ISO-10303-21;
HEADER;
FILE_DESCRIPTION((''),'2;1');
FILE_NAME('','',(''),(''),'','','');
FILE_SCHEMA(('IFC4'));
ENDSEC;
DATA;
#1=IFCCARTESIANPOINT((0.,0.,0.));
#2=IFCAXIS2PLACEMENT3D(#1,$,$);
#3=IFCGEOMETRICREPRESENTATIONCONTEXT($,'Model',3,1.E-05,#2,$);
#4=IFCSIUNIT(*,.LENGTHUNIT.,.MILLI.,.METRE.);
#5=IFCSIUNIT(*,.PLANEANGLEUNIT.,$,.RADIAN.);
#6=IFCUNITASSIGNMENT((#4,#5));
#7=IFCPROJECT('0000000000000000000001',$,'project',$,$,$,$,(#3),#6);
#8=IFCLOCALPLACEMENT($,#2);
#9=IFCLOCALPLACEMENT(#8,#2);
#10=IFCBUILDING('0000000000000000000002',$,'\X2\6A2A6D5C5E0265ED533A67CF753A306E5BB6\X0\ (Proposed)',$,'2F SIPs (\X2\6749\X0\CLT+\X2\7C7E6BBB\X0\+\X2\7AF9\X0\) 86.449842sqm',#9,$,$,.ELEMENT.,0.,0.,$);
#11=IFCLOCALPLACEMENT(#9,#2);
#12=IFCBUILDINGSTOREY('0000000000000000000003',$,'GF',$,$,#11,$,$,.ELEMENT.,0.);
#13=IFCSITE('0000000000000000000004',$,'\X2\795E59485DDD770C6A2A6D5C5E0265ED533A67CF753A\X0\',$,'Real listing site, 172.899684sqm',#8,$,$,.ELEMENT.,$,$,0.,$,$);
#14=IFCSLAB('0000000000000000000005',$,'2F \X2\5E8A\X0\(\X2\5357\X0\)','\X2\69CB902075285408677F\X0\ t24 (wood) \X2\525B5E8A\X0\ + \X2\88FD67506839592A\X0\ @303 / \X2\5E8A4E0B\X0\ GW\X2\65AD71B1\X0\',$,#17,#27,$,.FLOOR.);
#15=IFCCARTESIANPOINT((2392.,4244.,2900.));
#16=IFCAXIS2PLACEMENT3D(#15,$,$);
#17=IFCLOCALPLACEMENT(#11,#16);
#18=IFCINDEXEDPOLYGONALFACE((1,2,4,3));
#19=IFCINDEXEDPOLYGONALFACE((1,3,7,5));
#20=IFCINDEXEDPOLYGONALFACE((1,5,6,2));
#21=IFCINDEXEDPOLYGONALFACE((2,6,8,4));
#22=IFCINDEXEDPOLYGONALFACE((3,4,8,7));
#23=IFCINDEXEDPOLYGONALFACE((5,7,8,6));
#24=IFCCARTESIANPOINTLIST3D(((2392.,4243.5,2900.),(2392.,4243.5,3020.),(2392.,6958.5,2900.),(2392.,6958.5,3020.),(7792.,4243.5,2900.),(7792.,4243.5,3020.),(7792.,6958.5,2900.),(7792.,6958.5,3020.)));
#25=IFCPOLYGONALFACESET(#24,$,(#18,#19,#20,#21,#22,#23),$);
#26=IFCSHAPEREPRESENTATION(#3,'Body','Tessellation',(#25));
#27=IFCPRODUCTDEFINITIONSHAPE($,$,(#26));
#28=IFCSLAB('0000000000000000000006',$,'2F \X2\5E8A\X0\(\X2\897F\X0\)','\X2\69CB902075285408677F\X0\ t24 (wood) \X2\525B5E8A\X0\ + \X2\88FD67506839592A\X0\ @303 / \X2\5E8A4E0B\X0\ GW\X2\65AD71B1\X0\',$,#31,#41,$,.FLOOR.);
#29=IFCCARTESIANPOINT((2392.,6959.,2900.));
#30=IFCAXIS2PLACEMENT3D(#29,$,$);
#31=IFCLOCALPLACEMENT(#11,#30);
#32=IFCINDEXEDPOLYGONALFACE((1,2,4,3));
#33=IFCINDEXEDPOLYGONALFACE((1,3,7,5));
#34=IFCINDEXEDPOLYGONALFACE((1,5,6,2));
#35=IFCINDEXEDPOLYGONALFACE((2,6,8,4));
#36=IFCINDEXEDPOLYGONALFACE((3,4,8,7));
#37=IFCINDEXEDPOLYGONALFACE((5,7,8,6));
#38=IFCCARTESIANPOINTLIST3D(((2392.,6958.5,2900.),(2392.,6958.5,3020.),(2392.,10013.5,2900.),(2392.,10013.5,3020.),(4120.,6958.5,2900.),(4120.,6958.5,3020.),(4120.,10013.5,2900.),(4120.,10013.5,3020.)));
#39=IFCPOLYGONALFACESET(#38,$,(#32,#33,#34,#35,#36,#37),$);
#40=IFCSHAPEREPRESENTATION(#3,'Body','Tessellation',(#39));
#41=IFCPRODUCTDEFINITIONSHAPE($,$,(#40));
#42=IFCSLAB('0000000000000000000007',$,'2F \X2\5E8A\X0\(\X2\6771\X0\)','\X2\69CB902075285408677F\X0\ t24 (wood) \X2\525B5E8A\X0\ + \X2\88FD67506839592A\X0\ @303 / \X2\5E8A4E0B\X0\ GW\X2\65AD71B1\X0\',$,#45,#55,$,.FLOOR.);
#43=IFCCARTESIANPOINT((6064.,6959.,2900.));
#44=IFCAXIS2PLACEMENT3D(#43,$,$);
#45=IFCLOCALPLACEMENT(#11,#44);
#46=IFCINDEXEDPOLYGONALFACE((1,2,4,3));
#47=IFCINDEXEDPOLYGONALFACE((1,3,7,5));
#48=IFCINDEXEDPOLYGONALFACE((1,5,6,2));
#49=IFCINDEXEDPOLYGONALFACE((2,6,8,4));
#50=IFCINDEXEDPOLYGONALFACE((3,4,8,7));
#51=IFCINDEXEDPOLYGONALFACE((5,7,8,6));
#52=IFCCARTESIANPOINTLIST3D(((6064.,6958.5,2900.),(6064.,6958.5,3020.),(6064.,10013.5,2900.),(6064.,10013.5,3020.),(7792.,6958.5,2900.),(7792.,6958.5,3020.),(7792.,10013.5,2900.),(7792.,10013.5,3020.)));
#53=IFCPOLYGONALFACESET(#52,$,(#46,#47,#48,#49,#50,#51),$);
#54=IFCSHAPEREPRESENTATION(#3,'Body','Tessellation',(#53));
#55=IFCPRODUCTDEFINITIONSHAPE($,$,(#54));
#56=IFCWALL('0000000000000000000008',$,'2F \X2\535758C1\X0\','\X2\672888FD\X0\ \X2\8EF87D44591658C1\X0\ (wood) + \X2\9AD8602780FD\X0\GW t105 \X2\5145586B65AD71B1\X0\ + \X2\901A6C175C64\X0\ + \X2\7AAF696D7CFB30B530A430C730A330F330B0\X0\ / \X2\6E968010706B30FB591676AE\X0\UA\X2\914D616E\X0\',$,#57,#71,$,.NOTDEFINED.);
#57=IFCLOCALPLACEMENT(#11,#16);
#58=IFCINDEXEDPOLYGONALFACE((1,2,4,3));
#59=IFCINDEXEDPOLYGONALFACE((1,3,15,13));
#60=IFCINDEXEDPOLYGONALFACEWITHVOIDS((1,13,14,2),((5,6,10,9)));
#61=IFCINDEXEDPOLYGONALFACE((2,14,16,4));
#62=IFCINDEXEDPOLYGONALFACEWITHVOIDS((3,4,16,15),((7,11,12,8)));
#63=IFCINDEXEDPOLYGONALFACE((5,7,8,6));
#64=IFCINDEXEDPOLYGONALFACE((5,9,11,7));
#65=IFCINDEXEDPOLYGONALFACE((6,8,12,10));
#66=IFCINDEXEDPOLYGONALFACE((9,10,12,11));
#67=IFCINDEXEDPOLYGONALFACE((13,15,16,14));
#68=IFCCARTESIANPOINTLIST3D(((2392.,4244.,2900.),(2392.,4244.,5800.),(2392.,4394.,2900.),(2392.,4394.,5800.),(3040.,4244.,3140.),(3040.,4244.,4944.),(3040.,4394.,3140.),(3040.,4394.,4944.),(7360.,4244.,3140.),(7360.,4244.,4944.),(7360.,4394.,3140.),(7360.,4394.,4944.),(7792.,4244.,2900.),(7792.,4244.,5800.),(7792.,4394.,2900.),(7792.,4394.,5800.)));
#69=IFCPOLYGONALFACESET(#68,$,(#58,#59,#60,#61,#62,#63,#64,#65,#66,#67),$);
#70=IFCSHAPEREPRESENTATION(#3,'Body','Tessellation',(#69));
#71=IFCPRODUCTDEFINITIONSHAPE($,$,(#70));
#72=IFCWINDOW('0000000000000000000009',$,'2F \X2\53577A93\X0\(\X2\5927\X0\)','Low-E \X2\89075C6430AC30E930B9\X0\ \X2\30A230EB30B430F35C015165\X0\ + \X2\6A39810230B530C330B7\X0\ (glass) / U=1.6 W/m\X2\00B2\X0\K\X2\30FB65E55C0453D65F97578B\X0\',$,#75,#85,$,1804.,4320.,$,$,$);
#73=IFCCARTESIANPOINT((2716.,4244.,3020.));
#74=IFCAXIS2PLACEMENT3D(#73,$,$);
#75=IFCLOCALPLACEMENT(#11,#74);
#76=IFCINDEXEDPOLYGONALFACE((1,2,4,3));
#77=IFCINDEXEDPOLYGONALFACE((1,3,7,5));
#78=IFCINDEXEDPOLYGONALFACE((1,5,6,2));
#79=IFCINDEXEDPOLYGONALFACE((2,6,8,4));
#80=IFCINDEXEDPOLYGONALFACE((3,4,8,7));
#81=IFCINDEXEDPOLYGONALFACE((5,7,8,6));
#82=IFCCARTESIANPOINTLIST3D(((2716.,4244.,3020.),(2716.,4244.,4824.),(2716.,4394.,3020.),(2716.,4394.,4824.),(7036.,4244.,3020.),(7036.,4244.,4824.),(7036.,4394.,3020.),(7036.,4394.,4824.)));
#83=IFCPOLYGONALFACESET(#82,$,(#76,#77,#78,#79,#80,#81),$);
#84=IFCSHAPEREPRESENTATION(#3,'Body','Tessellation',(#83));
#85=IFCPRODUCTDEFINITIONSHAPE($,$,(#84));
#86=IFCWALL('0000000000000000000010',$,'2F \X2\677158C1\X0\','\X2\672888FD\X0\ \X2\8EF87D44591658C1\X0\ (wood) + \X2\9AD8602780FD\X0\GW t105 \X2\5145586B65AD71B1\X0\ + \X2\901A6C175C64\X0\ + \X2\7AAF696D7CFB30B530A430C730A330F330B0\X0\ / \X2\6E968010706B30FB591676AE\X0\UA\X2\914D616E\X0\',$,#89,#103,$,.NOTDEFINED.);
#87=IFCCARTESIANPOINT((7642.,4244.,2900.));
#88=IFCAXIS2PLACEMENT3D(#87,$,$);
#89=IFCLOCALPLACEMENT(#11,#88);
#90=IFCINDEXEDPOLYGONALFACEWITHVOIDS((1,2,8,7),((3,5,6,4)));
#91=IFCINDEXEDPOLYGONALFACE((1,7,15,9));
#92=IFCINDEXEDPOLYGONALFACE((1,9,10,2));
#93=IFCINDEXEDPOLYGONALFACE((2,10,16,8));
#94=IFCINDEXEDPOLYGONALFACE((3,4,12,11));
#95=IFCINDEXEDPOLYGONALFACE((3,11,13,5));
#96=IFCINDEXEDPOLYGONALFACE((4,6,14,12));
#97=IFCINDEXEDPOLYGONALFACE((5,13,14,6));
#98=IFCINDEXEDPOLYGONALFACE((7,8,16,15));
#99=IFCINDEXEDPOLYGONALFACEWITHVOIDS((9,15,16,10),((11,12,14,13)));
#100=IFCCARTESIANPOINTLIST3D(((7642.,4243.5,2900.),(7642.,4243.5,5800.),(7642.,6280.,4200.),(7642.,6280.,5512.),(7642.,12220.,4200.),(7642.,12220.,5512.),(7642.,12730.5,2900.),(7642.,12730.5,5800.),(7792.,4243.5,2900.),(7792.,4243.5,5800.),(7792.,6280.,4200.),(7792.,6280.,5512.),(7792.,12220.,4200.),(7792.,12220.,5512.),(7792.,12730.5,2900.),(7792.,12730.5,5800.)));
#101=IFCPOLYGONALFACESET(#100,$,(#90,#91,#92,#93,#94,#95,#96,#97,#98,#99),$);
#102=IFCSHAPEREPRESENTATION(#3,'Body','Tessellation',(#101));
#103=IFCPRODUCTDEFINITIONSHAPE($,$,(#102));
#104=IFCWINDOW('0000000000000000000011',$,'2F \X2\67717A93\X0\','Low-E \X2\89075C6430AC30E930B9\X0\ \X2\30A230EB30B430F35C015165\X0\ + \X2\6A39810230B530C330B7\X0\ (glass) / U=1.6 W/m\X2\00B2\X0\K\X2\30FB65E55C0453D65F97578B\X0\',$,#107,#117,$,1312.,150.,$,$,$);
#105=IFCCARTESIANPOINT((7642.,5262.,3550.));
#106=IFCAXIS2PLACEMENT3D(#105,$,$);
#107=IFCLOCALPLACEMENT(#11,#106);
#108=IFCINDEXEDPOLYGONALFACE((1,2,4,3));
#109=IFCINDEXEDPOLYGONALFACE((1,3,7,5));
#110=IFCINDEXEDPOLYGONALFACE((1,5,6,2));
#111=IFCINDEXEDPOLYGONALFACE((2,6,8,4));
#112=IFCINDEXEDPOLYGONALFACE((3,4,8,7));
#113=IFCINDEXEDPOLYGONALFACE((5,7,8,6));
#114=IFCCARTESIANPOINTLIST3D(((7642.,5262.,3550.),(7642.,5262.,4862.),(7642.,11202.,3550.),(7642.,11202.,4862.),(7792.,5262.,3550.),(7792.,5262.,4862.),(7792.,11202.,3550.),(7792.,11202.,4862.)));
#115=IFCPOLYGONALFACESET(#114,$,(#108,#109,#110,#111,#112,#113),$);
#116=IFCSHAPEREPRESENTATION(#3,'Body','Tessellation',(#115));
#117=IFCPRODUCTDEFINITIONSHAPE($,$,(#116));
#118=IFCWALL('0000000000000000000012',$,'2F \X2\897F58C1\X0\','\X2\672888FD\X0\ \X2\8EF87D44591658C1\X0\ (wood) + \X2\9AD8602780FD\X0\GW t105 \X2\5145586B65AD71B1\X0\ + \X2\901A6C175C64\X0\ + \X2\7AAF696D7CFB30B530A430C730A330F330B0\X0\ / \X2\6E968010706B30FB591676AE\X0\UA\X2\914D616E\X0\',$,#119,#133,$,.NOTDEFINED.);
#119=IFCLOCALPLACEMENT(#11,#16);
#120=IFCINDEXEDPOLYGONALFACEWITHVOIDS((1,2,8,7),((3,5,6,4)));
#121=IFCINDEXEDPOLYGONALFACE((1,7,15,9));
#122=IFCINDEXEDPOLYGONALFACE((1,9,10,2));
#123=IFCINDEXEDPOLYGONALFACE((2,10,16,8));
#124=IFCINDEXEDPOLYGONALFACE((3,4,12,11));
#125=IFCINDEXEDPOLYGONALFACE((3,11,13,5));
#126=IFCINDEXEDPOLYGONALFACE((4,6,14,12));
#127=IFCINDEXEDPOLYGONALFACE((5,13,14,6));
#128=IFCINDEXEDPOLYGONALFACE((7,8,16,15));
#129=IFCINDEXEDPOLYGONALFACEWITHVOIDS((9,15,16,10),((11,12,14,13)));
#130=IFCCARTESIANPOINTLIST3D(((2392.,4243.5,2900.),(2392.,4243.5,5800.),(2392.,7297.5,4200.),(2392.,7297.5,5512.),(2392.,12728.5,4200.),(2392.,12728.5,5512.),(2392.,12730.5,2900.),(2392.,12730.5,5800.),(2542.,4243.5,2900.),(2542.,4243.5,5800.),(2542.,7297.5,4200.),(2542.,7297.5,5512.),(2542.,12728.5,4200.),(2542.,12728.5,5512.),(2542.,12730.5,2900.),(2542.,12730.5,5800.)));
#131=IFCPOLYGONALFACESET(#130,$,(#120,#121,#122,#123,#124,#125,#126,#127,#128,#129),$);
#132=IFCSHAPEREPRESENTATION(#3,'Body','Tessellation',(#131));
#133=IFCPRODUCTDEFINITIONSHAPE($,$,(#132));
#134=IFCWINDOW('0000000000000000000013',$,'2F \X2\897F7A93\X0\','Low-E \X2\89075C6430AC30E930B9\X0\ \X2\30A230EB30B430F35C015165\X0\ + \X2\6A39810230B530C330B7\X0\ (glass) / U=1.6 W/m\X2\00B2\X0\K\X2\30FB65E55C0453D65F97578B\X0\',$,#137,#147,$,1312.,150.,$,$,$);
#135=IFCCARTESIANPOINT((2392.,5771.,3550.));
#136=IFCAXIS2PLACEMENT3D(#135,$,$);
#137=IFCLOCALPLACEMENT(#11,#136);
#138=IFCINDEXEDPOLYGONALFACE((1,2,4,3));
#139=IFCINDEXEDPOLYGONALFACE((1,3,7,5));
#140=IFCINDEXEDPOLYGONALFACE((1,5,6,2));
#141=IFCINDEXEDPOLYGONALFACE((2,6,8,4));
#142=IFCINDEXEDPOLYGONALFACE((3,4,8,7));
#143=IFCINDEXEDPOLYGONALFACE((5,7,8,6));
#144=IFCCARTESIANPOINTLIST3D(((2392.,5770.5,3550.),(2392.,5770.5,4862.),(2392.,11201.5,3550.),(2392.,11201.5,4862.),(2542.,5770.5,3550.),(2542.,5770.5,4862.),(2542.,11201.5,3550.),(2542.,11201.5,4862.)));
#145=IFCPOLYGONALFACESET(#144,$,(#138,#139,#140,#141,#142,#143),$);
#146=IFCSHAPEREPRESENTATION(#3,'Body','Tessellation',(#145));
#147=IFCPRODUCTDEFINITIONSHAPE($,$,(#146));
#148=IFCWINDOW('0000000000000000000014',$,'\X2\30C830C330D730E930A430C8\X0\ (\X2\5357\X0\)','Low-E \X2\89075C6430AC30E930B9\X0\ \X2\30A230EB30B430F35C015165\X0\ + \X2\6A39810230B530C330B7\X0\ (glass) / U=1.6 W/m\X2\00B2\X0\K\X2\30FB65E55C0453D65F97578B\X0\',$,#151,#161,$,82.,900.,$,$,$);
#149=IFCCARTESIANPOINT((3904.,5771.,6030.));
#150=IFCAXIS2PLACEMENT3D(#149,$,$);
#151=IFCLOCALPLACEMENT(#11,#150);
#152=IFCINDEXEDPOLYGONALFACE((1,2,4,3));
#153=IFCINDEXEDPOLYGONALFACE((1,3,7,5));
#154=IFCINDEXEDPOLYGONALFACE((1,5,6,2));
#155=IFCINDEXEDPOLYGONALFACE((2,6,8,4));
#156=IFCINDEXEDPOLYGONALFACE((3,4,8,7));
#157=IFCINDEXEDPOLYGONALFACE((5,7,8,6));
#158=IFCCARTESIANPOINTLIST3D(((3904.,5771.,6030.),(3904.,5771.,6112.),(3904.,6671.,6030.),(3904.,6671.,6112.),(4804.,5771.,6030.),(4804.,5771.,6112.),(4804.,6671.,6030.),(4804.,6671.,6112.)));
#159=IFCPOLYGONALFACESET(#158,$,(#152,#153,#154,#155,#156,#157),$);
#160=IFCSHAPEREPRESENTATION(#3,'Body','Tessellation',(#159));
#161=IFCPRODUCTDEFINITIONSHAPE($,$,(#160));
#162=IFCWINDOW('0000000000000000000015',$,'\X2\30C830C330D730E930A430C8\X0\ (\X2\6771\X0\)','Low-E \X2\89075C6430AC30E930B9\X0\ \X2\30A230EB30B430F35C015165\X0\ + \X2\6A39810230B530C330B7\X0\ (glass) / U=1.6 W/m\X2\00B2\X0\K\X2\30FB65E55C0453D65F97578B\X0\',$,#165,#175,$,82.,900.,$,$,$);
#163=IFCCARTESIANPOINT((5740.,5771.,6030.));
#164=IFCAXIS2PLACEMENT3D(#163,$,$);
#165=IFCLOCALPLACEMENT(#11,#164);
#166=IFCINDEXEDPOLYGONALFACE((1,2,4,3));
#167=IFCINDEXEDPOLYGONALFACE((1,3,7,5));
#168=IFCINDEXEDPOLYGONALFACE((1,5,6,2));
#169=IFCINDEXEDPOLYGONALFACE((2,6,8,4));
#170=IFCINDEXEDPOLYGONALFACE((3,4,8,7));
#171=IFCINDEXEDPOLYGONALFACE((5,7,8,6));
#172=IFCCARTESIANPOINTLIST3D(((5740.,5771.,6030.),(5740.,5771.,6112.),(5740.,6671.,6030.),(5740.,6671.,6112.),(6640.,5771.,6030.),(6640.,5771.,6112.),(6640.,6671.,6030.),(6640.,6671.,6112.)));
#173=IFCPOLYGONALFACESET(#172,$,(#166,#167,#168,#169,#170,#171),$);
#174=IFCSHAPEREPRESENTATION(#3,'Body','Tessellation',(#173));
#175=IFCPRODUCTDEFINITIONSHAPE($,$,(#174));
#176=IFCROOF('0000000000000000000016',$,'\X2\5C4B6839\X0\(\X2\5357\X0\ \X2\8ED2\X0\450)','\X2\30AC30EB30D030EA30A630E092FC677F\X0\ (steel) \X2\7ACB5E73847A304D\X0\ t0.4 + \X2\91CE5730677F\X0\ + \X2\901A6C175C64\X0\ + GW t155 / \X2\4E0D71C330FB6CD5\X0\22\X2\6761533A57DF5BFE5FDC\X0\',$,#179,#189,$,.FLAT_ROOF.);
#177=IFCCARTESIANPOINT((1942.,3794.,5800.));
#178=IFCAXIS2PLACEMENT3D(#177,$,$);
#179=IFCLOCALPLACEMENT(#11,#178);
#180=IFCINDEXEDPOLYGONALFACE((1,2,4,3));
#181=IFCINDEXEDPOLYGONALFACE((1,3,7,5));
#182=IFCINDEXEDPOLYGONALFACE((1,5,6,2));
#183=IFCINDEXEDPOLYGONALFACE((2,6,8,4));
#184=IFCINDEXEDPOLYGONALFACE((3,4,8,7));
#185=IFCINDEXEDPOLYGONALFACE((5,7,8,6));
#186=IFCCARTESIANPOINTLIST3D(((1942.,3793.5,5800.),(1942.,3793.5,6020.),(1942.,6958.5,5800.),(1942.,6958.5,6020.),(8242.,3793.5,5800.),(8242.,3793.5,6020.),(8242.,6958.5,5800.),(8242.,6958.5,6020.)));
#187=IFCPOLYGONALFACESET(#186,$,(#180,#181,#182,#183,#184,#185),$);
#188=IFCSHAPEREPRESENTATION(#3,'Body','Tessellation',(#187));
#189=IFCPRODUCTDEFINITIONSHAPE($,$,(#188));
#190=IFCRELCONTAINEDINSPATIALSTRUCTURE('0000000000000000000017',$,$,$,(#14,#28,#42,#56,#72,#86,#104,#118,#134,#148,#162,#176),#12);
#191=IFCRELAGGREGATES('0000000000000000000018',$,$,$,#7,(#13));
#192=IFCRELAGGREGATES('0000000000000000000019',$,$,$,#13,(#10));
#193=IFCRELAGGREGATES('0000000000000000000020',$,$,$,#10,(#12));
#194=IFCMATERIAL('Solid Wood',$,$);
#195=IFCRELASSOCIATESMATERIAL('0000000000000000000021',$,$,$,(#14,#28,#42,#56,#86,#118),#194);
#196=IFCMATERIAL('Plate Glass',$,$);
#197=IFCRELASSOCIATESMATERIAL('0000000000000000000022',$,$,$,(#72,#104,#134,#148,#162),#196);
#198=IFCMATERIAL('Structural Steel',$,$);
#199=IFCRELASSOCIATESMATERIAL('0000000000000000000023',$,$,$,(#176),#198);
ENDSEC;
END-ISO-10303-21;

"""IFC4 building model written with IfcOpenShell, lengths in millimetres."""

from ifc_helpers import new_model, si_unit, frame, frame_2d, origin, place, context, project, spatial, rectangle, extrude, material, element, fill, save


model = new_model("IFC4")

# Units and contexts
model_context = context("Model", 3, precision=1e-05, world=origin())
ifc_project = project(units=[si_unit("LENGTHUNIT", "METRE", prefix="MILLI"), si_unit("PLANEANGLEUNIT", "RADIAN")], contexts=[model_context])

# Site, building, storey
site_placement = place(None, origin())
site = spatial("IfcSite", under=ifc_project, at=site_placement, Name="神奈川県横浜市旭区柏町", ObjectType="Real listing site, 172.899684sqm", CompositionType="ELEMENT", RefElevation=0.0)
building_placement = place(site_placement, origin())
building = spatial("IfcBuilding", under=site, at=building_placement, Name="横浜市旭区柏町の家 (Proposed)", ObjectType="2F SIPs (杉CLT+籾殻+竹) 86.449842sqm", CompositionType="ELEMENT", ElevationOfRefHeight=0.0, ElevationOfTerrain=0.0)
storey_placement = place(building_placement, origin())
storey = spatial("IfcBuildingStorey", under=building, at=storey_placement, Name="GF", CompositionType="ELEMENT", Elevation=0.0)

# Slabs
ifc_material_1 = material(Name="Solid Wood")
slab_1_placement = place(storey_placement, frame((2392.0, 4244.0, 2900.0)))
element("IfcSlab", 1, at=slab_1_placement, inside=storey, material=ifc_material_1, Name="2F 床(南)", Description="構造用合板 t24 (wood) 剛床 + 製材根太 @303 / 床下 GW断熱", PredefinedType="FLOOR", context=model_context, shape_type="SweptSolid", body=[
    extrude(rectangle(XDim=5400.0, YDim=2715.0, at=frame_2d((2700.0, 1357.0))), frame((2392.0, 4244.0, 2900.0)), (0.0, 0.0, 1.0), 120.0),
])
slab_2_placement = place(storey_placement, frame((2392.0, 6959.0, 2900.0)))
element("IfcSlab", 2, at=slab_2_placement, inside=storey, material=ifc_material_1, Name="2F 床(西)", Description="構造用合板 t24 (wood) 剛床 + 製材根太 @303 / 床下 GW断熱", PredefinedType="FLOOR", context=model_context, shape_type="SweptSolid", body=[
    extrude(rectangle(XDim=1728.0, YDim=3055.0, at=frame_2d((864.0, 1527.0))), frame((2392.0, 6959.0, 2900.0)), (0.0, 0.0, 1.0), 120.0),
])
slab_3_placement = place(storey_placement, frame((6064.0, 6959.0, 2900.0)))
element("IfcSlab", 3, at=slab_3_placement, inside=storey, material=ifc_material_1, Name="2F 床(東)", Description="構造用合板 t24 (wood) 剛床 + 製材根太 @303 / 床下 GW断熱", PredefinedType="FLOOR", context=model_context, shape_type="SweptSolid", body=[
    extrude(rectangle(XDim=1728.0, YDim=3055.0, at=frame_2d((864.0, 1527.0))), frame((6064.0, 6959.0, 2900.0)), (0.0, 0.0, 1.0), 120.0),
])

# Walls, openings, windows
wall_1_placement = place(storey_placement, frame((2392.0, 4244.0, 2900.0)))
wall_1 = element("IfcWall", 4, at=wall_1_placement, inside=storey, material=ifc_material_1, Name="2F 南壁", Description="木製 軸組外壁 (wood) + 高性能GW t105 充填断熱 + 通気層 + 窯業系サイディング / 準耐火・外皮UA配慮", PredefinedType="NOTDEFINED", context=model_context, shape_type="SweptSolid", body=[
    extrude(rectangle(XDim=5400.0, YDim=150.0, at=frame_2d((2700.0, 75.0))), frame((2392.0, 4244.0, 2900.0)), (0.0, 0.0, 1.0), 2900.0),
])
opening_1_placement = place(storey_placement, frame((2716.0, 4244.0, 3020.0)))
opening_1 = element("IfcOpeningElement", 5, at=opening_1_placement, cuts=wall_1, PredefinedType="NOTDEFINED", context=model_context, shape_type="SweptSolid", body=[
    extrude(rectangle(XDim=4320.0, YDim=150.0, at=frame_2d((2160.0, 75.0))), frame((2716.0, 4244.0, 3020.0)), (0.0, 0.0, 1.0), 1804.0),
])
ifc_material_2 = material(Name="Plate Glass")
window_1_placement = place(storey_placement, frame((2716.0, 4244.0, 3020.0)))
window_1 = element("IfcWindow", 6, at=window_1_placement, inside=storey, material=ifc_material_2, Name="2F 南窓(大)", Description="Low-E 複層ガラス アルゴン封入 + 樹脂サッシ (glass) / U=1.6 W/m²K・日射取得型", OverallHeight=1804.0, OverallWidth=4320.0, context=model_context, shape_type="SweptSolid", body=[
    extrude(rectangle(XDim=4320.0, YDim=150.0, at=frame_2d((2160.0, 75.0))), frame((2716.0, 4244.0, 3020.0)), (0.0, 0.0, 1.0), 1804.0),
])
fill(opening_1, window_1)
wall_2_placement = place(storey_placement, frame((7642.0, 4244.0, 2900.0)))
wall_2 = element("IfcWall", 7, at=wall_2_placement, inside=storey, material=ifc_material_1, Name="2F 東壁", Description="木製 軸組外壁 (wood) + 高性能GW t105 充填断熱 + 通気層 + 窯業系サイディング / 準耐火・外皮UA配慮", PredefinedType="NOTDEFINED", context=model_context, shape_type="SweptSolid", body=[
    extrude(rectangle(XDim=150.0, YDim=8487.0, at=frame_2d((75.0, 4243.0))), frame((7642.0, 4244.0, 2900.0)), (0.0, 0.0, 1.0), 2900.0),
])
opening_2_placement = place(storey_placement, frame((7642.0, 5262.0, 3550.0)))
opening_2 = element("IfcOpeningElement", 8, at=opening_2_placement, cuts=wall_2, PredefinedType="NOTDEFINED", context=model_context, shape_type="SweptSolid", body=[
    extrude(rectangle(XDim=150.0, YDim=5940.0, at=frame_2d((75.0, 2970.0))), frame((7642.0, 5262.0, 3550.0)), (0.0, 0.0, 1.0), 1312.0),
])
window_2_placement = place(storey_placement, frame((7642.0, 5262.0, 3550.0)))
window_2 = element("IfcWindow", 9, at=window_2_placement, inside=storey, material=ifc_material_2, Name="2F 東窓", Description="Low-E 複層ガラス アルゴン封入 + 樹脂サッシ (glass) / U=1.6 W/m²K・日射取得型", OverallHeight=1312.0, OverallWidth=150.0, context=model_context, shape_type="SweptSolid", body=[
    extrude(rectangle(XDim=150.0, YDim=5940.0, at=frame_2d((75.0, 2970.0))), frame((7642.0, 5262.0, 3550.0)), (0.0, 0.0, 1.0), 1312.0),
])
fill(opening_2, window_2)
wall_3_placement = place(storey_placement, frame((2392.0, 4244.0, 2900.0)))
wall_3 = element("IfcWall", 10, at=wall_3_placement, inside=storey, material=ifc_material_1, Name="2F 西壁", Description="木製 軸組外壁 (wood) + 高性能GW t105 充填断熱 + 通気層 + 窯業系サイディング / 準耐火・外皮UA配慮", PredefinedType="NOTDEFINED", context=model_context, shape_type="SweptSolid", body=[
    extrude(rectangle(XDim=150.0, YDim=8487.0, at=frame_2d((75.0, 4243.0))), frame((2392.0, 4244.0, 2900.0)), (0.0, 0.0, 1.0), 2900.0),
])
opening_3_placement = place(storey_placement, frame((2392.0, 5771.0, 3550.0)))
opening_3 = element("IfcOpeningElement", 11, at=opening_3_placement, cuts=wall_3, PredefinedType="NOTDEFINED", context=model_context, shape_type="SweptSolid", body=[
    extrude(rectangle(XDim=150.0, YDim=5431.0, at=frame_2d((75.0, 2715.0))), frame((2392.0, 5771.0, 3550.0)), (0.0, 0.0, 1.0), 1312.0),
])
window_3_placement = place(storey_placement, frame((2392.0, 5771.0, 3550.0)))
window_3 = element("IfcWindow", 12, at=window_3_placement, inside=storey, material=ifc_material_2, Name="2F 西窓", Description="Low-E 複層ガラス アルゴン封入 + 樹脂サッシ (glass) / U=1.6 W/m²K・日射取得型", OverallHeight=1312.0, OverallWidth=150.0, context=model_context, shape_type="SweptSolid", body=[
    extrude(rectangle(XDim=150.0, YDim=5431.0, at=frame_2d((75.0, 2715.0))), frame((2392.0, 5771.0, 3550.0)), (0.0, 0.0, 1.0), 1312.0),
])
fill(opening_3, window_3)

# Windows
window_4_placement = place(storey_placement, frame((3904.0, 5771.0, 6030.0)))
element("IfcWindow", 13, at=window_4_placement, inside=storey, material=ifc_material_2, Name="トップライト (南)", Description="Low-E 複層ガラス アルゴン封入 + 樹脂サッシ (glass) / U=1.6 W/m²K・日射取得型", OverallHeight=82.0, OverallWidth=900.0, context=model_context, shape_type="SweptSolid", body=[
    extrude(rectangle(XDim=900.0, YDim=900.0, at=frame_2d((450.0, 450.0))), frame((3904.0, 5771.0, 6030.0)), (0.0, 0.0, 1.0), 82.0),
])
window_5_placement = place(storey_placement, frame((5740.0, 5771.0, 6030.0)))
element("IfcWindow", 14, at=window_5_placement, inside=storey, material=ifc_material_2, Name="トップライト (東)", Description="Low-E 複層ガラス アルゴン封入 + 樹脂サッシ (glass) / U=1.6 W/m²K・日射取得型", OverallHeight=82.0, OverallWidth=900.0, context=model_context, shape_type="SweptSolid", body=[
    extrude(rectangle(XDim=900.0, YDim=900.0, at=frame_2d((450.0, 450.0))), frame((5740.0, 5771.0, 6030.0)), (0.0, 0.0, 1.0), 82.0),
])

# Roof
ifc_material_3 = material(Name="Structural Steel")
roof_1_placement = place(storey_placement, frame((1942.0, 3794.0, 5800.0)))
element("IfcRoof", 15, at=roof_1_placement, inside=storey, material=ifc_material_3, Name="屋根(南 軒450)", Description="ガルバリウム鋼板 (steel) 立平葺き t0.4 + 野地板 + 通気層 + GW t155 / 不燃・法22条区域対応", PredefinedType="FLAT_ROOF", context=model_context, shape_type="SweptSolid", body=[
    extrude(rectangle(XDim=6300.0, YDim=3165.0, at=frame_2d((3150.0, 1582.0))), frame((1942.0, 3794.0, 5800.0)), (0.0, 0.0, 1.0), 220.0),
])

save(model, "model.ifc")
